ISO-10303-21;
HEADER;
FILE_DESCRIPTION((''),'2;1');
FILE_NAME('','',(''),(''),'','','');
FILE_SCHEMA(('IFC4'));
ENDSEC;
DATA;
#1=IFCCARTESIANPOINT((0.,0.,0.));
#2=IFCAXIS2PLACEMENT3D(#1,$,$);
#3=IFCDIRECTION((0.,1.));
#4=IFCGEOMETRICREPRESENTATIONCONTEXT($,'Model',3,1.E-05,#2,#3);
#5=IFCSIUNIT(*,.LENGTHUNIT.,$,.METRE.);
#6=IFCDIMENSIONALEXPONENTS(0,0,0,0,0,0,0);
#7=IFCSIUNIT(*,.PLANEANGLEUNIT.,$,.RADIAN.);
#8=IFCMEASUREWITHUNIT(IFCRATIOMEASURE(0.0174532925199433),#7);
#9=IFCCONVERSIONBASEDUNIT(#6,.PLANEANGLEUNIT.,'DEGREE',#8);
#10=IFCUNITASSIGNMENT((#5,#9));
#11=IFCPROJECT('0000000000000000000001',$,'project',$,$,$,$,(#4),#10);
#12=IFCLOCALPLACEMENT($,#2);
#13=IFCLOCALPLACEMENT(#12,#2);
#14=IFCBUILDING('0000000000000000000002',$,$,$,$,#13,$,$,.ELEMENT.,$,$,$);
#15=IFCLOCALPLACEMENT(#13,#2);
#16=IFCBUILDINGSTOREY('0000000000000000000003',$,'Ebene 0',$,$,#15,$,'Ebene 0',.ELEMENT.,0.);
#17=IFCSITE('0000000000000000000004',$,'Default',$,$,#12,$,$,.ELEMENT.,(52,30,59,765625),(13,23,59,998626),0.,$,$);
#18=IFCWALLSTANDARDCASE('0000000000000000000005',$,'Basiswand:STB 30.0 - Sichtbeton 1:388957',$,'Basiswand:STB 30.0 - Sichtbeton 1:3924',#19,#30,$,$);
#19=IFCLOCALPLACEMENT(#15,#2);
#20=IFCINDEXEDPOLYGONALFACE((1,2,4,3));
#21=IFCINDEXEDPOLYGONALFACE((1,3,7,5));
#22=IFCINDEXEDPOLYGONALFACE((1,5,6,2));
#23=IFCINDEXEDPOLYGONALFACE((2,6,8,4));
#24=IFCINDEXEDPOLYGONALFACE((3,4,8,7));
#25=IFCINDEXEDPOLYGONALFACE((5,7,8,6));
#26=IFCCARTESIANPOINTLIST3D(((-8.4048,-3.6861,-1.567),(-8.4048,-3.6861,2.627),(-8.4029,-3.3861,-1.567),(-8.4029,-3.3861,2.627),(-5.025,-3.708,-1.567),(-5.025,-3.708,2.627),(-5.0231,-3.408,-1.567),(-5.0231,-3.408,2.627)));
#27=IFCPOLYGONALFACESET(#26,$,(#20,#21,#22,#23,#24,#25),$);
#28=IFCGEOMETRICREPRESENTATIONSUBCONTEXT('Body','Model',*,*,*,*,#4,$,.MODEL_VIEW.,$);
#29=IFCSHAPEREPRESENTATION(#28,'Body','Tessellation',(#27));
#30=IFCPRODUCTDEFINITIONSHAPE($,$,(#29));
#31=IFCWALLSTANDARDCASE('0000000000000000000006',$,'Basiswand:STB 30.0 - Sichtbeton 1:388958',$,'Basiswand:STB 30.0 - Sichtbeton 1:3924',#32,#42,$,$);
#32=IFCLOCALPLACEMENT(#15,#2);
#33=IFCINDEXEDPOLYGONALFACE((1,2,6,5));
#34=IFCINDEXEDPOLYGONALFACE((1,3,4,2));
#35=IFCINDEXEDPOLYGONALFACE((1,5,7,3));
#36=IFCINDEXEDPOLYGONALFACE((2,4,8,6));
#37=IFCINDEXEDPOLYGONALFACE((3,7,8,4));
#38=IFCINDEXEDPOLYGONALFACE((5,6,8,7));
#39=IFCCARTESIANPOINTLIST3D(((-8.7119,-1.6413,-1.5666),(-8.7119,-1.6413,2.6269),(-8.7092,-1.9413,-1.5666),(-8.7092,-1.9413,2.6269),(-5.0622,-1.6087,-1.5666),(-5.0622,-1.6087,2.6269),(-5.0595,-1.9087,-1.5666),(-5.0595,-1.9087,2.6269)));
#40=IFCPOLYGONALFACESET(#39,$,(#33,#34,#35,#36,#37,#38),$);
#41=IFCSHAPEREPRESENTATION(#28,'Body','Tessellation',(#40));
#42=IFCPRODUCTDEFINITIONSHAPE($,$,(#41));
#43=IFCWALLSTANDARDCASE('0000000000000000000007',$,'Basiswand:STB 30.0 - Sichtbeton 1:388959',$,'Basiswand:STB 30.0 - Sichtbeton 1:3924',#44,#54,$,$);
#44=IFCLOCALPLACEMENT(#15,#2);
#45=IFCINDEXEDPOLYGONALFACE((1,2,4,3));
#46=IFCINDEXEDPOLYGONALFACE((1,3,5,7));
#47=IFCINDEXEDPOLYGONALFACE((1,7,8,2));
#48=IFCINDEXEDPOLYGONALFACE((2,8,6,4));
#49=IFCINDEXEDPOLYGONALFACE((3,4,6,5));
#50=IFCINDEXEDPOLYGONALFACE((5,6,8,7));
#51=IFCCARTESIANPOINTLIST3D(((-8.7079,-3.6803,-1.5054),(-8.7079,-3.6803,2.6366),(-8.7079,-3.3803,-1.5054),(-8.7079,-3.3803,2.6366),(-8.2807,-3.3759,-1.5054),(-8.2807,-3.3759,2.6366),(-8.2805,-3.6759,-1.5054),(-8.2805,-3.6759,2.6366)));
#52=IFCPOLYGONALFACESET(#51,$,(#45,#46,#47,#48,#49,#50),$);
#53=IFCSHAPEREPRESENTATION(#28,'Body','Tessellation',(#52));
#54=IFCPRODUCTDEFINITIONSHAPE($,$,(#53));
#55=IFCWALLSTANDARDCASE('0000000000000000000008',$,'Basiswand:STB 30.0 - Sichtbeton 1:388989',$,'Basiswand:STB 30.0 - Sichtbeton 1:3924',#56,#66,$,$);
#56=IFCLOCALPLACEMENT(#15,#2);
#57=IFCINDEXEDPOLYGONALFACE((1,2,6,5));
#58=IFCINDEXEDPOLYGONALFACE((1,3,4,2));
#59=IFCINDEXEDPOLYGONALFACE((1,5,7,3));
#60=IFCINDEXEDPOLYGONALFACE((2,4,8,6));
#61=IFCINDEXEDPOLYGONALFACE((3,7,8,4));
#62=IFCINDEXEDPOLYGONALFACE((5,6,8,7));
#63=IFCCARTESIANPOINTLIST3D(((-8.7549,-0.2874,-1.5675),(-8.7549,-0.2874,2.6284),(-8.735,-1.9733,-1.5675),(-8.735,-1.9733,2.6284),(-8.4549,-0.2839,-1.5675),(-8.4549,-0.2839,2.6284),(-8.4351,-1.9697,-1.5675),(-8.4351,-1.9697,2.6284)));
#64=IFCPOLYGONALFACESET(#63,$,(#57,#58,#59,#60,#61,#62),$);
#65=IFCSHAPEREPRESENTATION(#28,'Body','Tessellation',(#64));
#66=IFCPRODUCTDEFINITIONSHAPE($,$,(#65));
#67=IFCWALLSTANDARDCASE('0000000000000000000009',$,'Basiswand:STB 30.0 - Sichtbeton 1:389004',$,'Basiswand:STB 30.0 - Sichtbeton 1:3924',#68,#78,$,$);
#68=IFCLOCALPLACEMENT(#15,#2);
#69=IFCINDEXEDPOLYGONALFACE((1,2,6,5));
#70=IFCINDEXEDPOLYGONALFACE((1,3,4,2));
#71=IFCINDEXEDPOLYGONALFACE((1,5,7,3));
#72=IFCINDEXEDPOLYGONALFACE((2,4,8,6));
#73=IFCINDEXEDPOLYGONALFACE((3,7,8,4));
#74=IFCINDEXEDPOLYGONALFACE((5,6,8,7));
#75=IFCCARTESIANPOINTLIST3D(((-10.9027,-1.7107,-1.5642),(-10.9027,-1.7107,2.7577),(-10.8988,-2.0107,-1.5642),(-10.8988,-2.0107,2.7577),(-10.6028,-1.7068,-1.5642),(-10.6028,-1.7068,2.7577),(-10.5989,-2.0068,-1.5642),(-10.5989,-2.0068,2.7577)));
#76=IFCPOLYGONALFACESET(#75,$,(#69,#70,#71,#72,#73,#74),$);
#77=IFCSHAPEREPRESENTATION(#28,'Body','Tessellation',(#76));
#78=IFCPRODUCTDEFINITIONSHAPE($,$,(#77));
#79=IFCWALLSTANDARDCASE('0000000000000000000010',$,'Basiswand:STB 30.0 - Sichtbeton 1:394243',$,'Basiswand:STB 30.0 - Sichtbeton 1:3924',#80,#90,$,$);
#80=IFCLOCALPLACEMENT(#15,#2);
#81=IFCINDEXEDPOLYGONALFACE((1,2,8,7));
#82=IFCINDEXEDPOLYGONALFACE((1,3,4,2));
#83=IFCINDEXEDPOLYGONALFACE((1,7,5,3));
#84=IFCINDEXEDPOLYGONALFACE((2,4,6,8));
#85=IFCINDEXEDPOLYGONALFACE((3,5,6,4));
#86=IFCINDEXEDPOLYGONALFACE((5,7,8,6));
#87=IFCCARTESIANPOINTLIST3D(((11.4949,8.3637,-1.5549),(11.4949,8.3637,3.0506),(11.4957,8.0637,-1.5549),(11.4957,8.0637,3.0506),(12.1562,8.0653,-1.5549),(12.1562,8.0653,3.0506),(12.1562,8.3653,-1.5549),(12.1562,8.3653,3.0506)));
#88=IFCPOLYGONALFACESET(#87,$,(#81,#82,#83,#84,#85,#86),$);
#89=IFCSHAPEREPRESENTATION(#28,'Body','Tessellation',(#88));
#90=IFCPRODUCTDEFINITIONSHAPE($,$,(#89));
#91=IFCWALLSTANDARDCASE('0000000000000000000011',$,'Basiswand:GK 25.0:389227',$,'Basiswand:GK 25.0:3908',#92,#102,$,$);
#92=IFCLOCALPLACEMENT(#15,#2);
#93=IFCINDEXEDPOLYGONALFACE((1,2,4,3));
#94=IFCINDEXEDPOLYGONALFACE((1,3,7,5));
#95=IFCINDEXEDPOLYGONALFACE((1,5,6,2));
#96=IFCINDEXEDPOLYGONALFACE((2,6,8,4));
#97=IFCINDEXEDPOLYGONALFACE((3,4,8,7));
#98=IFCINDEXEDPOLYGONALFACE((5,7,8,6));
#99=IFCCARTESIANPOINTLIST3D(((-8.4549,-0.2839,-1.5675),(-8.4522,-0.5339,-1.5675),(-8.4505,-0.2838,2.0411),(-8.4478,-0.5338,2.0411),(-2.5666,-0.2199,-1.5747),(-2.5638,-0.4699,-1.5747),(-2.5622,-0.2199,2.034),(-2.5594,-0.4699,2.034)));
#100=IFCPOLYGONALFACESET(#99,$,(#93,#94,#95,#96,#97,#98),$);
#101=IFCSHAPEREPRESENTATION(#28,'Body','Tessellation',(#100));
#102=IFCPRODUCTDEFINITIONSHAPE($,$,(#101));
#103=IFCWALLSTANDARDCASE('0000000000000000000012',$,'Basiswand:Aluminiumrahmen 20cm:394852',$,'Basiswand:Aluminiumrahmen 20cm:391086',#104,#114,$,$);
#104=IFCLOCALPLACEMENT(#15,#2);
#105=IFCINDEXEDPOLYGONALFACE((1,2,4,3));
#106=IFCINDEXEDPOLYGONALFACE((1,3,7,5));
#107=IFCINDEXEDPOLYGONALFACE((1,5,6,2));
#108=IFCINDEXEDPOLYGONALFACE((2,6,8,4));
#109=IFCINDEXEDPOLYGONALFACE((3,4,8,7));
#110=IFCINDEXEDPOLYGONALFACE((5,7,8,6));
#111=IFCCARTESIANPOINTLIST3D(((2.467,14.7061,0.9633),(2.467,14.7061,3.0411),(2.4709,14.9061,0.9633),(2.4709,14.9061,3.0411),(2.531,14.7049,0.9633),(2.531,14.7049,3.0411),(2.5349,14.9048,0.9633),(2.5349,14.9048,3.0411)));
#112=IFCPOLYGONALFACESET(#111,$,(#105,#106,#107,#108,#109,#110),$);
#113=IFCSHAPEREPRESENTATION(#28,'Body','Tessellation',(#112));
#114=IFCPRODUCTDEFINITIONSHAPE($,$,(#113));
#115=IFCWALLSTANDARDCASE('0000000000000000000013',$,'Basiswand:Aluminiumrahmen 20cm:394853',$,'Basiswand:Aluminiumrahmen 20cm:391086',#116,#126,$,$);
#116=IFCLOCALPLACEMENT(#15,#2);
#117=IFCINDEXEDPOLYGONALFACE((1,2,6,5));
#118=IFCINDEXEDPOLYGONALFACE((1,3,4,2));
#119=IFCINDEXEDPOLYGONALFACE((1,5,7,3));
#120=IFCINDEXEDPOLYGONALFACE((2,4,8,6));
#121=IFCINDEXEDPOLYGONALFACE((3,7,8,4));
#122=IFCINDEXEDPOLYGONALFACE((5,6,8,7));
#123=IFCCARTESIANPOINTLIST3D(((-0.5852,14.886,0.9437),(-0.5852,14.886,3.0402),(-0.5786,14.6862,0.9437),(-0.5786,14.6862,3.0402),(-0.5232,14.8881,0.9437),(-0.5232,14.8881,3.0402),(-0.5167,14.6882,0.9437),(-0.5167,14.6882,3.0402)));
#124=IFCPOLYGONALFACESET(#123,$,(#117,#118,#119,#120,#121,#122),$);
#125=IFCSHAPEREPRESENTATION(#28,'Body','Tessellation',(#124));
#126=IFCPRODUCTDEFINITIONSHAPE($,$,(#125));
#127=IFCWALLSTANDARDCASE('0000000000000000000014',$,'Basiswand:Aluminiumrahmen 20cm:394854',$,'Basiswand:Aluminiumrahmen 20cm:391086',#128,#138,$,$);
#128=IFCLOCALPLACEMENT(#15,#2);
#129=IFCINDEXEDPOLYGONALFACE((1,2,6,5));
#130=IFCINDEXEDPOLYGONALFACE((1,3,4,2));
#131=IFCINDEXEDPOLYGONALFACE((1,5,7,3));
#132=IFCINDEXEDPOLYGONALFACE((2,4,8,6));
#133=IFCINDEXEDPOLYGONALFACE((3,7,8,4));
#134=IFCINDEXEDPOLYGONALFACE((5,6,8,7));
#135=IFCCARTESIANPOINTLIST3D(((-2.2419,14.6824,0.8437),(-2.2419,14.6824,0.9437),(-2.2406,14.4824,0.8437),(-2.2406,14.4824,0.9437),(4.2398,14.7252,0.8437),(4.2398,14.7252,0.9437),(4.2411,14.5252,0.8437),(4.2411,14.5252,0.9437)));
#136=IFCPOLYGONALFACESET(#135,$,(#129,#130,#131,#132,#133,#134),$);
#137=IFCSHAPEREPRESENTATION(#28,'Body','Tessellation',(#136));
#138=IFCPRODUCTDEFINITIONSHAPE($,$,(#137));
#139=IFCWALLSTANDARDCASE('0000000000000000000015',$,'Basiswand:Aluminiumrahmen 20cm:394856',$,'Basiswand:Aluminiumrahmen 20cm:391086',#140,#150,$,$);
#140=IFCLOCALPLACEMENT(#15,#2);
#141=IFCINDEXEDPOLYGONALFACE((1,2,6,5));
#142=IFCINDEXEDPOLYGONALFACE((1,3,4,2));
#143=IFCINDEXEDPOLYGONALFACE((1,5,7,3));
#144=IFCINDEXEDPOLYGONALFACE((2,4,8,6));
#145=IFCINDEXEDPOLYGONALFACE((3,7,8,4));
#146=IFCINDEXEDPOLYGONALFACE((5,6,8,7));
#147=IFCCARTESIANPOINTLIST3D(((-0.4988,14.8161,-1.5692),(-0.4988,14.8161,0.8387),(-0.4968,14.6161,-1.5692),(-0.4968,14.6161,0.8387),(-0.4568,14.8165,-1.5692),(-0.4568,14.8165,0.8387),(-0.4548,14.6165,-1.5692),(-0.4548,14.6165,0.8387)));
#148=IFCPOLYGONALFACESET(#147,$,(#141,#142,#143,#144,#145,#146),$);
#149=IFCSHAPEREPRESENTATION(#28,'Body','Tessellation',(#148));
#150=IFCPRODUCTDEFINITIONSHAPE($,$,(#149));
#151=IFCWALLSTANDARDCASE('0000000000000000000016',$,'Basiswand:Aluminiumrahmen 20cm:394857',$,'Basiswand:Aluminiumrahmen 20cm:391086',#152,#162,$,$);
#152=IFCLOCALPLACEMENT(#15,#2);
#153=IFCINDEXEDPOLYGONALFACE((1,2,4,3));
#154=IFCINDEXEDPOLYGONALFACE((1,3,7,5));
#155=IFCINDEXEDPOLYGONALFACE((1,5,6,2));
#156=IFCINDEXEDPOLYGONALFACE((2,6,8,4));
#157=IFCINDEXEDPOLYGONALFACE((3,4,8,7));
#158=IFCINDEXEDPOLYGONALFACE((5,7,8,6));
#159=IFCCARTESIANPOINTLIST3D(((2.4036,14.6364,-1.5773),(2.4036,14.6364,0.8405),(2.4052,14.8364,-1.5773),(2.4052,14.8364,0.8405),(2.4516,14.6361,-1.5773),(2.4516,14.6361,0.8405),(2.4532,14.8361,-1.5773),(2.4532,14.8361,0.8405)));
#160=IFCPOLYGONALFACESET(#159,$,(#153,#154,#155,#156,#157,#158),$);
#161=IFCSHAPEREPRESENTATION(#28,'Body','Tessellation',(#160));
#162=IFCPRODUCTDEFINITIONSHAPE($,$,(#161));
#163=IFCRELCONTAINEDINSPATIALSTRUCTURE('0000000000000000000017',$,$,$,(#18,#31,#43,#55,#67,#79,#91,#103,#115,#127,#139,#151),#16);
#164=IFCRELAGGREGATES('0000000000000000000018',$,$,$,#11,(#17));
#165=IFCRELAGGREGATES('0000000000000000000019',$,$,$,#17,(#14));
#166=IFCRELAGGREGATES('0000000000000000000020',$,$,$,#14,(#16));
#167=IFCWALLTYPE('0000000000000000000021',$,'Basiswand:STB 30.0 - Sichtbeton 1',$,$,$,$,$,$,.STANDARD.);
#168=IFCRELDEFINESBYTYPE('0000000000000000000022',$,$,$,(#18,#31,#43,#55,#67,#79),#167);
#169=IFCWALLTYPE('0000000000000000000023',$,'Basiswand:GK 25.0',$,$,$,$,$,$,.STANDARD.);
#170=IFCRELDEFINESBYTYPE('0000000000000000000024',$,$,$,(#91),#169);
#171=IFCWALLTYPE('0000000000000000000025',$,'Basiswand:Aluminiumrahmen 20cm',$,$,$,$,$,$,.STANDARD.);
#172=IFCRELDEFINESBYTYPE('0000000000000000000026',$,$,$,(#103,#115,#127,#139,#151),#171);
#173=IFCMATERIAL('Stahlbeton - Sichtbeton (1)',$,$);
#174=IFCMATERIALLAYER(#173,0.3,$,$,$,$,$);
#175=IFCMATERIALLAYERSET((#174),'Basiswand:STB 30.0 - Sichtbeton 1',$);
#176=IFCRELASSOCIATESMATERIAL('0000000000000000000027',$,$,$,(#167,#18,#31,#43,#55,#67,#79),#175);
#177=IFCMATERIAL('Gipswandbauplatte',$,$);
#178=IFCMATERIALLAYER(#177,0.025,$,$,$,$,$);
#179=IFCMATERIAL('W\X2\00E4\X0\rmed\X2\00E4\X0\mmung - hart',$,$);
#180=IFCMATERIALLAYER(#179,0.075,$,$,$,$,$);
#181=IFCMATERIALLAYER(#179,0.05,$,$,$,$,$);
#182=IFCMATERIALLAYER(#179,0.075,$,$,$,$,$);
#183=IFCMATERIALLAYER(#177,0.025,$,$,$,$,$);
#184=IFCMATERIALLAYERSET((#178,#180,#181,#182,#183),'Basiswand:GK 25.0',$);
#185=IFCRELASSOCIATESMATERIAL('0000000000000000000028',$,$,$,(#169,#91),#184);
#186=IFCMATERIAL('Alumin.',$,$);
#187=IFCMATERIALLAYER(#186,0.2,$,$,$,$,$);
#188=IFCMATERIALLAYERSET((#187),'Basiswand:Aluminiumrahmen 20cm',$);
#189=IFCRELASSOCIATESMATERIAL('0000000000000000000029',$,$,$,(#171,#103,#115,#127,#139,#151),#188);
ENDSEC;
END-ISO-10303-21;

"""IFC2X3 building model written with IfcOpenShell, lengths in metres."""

from ifc_helpers import new_model, entity, si_unit, converted_unit, direction, frame, frame_2d, origin, place, context, subcontext, project, spatial, polyline, rectangle, outline, extrude, clip, halfspace, material, layer, layer_set, layer_usage, type_object, element, save


model = new_model("IFC2X3")

# Units and contexts
model_context = context("Model", 3, precision=1e-05, world=origin(), true_north=direction((0.0, 1.0)))
body_context = subcontext(model_context, "Body", "Model", "MODEL_VIEW")
ifc_project = project(units=[si_unit("LENGTHUNIT", "METRE"), converted_unit("PLANEANGLEUNIT", "DEGREE", entity("IfcRatioMeasure", 0.0174532925199433), si_unit("PLANEANGLEUNIT", "RADIAN"), dimensions=[0, 0, 0, 0, 0, 0, 0])], contexts=[model_context])

# Site, building, storey
site_placement = place(None, origin())
site = spatial("IfcSite", under=ifc_project, at=site_placement, Name="Default", CompositionType="ELEMENT", RefLatitude=(52, 30, 59, 765625), RefLongitude=(13, 23, 59, 998626), RefElevation=0.0)
building_placement = place(site_placement, origin())
building = spatial("IfcBuilding", under=site, at=building_placement, CompositionType="ELEMENT")
storey_placement = place(building_placement, origin())
storey = spatial("IfcBuildingStorey", under=building, at=storey_placement, Name="Ebene 0", LongName="Ebene 0", CompositionType="ELEMENT", Elevation=0.0)

# Walls
ifc_material_1 = material(Name="Stahlbeton - Sichtbeton (1)")
ifc_layer_1 = layer(ifc_material_1, 0.3)
ifc_layer_set_1 = layer_set([ifc_layer_1], Name="Basiswand:STB 30.0 - Sichtbeton 1")
ifc_layer_usage_1 = layer_usage(ifc_layer_set_1, "AXIS2", "POSITIVE", -0.15)
wall_type_1 = type_object("IfcWallType", Name="Basiswand:STB 30.0 - Sichtbeton 1", PredefinedType="STANDARD", material=ifc_layer_set_1)
wall_1_placement = place(storey_placement, frame((-5.024, -3.558, -1.567), z_axis=(0.0, 0.0, 1.0), x_axis=(-0.999979, 0.006472, 0.0)))
element("IfcWallStandardCase", 1, at=wall_1_placement, inside=storey, type_object=wall_type_1, material=ifc_layer_usage_1, Name="Basiswand:STB 30.0 - Sichtbeton 1:388957", ObjectType="Basiswand:STB 30.0 - Sichtbeton 1:3924", context=body_context, shape_type="SweptSolid", body=[
    extrude(rectangle(XDim=3.3799, YDim=0.3, at=frame_2d((1.69, 0.0), x_axis=(-1.0, 0.0))), origin(), (0.0, 0.0, 1.0), 4.194),
])
ifc_layer_usage_2 = layer_usage(ifc_layer_set_1, "AXIS2", "POSITIVE", -0.15)
wall_2_placement = place(storey_placement, frame((-5.0608, -1.7587, -1.5666), z_axis=(0.0, 0.0, 1.0), x_axis=(-0.99996, -0.008941, 0.0)))
element("IfcWallStandardCase", 2, at=wall_2_placement, inside=storey, type_object=wall_type_1, material=ifc_layer_usage_2, Name="Basiswand:STB 30.0 - Sichtbeton 1:388958", ObjectType="Basiswand:STB 30.0 - Sichtbeton 1:3924", context=body_context, shape_type="SweptSolid", body=[
    extrude(rectangle(XDim=3.6498, YDim=0.3, at=frame_2d((1.8249, 0.0), x_axis=(-1.0, 0.0))), origin(), (0.0, 0.0, 1.0), 4.1935),
])
ifc_layer_usage_3 = layer_usage(ifc_layer_set_1, "AXIS2", "POSITIVE", -0.15)
wall_3_placement = place(storey_placement, frame((-8.2792, -3.5259, -1.5054), z_axis=(0.0, 0.0, 1.0), x_axis=(-0.999946, -0.010349, 0.0)))
element("IfcWallStandardCase", 3, at=wall_3_placement, inside=storey, type_object=wall_type_1, material=ifc_layer_usage_3, Name="Basiswand:STB 30.0 - Sichtbeton 1:388959", ObjectType="Basiswand:STB 30.0 - Sichtbeton 1:3924", context=body_context, shape_type="SweptSolid", body=[
    extrude(outline(polyline([(-0.1478, -0.2136), (0.1522, -0.2136), (0.1478, 0.2138), (-0.1522, 0.2135), (-0.1478, -0.2136)])), frame((0.2151, 0.0, 0.0), z_axis=(0.0, 0.0, 1.0), x_axis=(0.010349, 0.999946, 0.0)), (0.0, 0.0, 1.0), 4.142),
])
ifc_layer_usage_4 = layer_usage(ifc_layer_set_1, "AXIS2", "POSITIVE", -0.15)
wall_4_placement = place(storey_placement, frame((-8.585, -1.9715, -1.5675), z_axis=(0.0, 0.0, 1.0), x_axis=(-0.011764, 0.999931, 0.0)))
element("IfcWallStandardCase", 4, at=wall_4_placement, inside=storey, type_object=wall_type_1, material=ifc_layer_usage_4, Name="Basiswand:STB 30.0 - Sichtbeton 1:388989", ObjectType="Basiswand:STB 30.0 - Sichtbeton 1:3924", context=body_context, shape_type="SweptSolid", body=[
    extrude(rectangle(XDim=1.686, YDim=0.3, at=frame_2d((0.843, 0.0), x_axis=(-1.0, 0.0))), origin(), (0.0, 0.0, 1.0), 4.196),
])
ifc_layer_usage_5 = layer_usage(ifc_layer_set_1, "AXIS2", "POSITIVE", -0.15)
wall_5_placement = place(storey_placement, frame((-10.7528, -1.7087, -1.5642), z_axis=(0.0, 0.0, 1.0), x_axis=(0.013004, -0.999915, 0.0)))
element("IfcWallStandardCase", 5, at=wall_5_placement, inside=storey, type_object=wall_type_1, material=ifc_layer_usage_5, Name="Basiswand:STB 30.0 - Sichtbeton 1:389004", ObjectType="Basiswand:STB 30.0 - Sichtbeton 1:3924", context=body_context, shape_type="SweptSolid", body=[
    extrude(rectangle(XDim=0.3, YDim=0.3, at=frame_2d((0.15, 0.0), x_axis=(-1.0, 0.0))), origin(), (0.0, 0.0, 1.0), 4.3219),
])
ifc_layer_usage_6 = layer_usage(ifc_layer_set_1, "AXIS2", "POSITIVE", -0.15)
wall_6_placement = place(storey_placement, frame((11.4953, 8.2137, -1.5549), z_axis=(0.0, 0.0, 1.0), x_axis=(0.999997, 0.002516, 0.0)))
element("IfcWallStandardCase", 6, at=wall_6_placement, inside=storey, type_object=wall_type_1, material=ifc_layer_usage_6, Name="Basiswand:STB 30.0 - Sichtbeton 1:394243", ObjectType="Basiswand:STB 30.0 - Sichtbeton 1:3924", context=body_context, shape_type="SweptSolid", body=[
    extrude(outline(polyline([(-0.1492, -0.3305), (0.1508, -0.3305), (0.1492, 0.3309), (-0.1508, 0.3301), (-0.1492, -0.3305)])), frame((0.3305, 0.0, 0.0), z_axis=(0.0, 0.0, 1.0), x_axis=(0.002516, 0.999997, 0.0)), (0.0, 0.0, 1.0), 4.6055),
])
ifc_material_2 = material(Name="Gipswandbauplatte")
ifc_layer_2 = layer(ifc_material_2, 0.025)
ifc_material_3 = material(Name="Wärmedämmung - hart")
ifc_layer_3 = layer(ifc_material_3, 0.075)
ifc_layer_4 = layer(ifc_material_3, 0.05)
ifc_layer_5 = layer(ifc_material_3, 0.075)
ifc_layer_6 = layer(ifc_material_2, 0.025)
ifc_layer_set_2 = layer_set([ifc_layer_2, ifc_layer_3, ifc_layer_4, ifc_layer_5, ifc_layer_6], Name="Basiswand:GK 25.0")
ifc_layer_usage_7 = layer_usage(ifc_layer_set_2, "AXIS2", "POSITIVE", -0.125)
wall_type_2 = type_object("IfcWallType", Name="Basiswand:GK 25.0", PredefinedType="STANDARD", material=ifc_layer_set_2)
wall_7_placement = place(storey_placement, frame((-8.4535, -0.4089, -1.5747), z_axis=(0.0, 0.0, 1.0), x_axis=(0.999941, 0.010858, 0.0)))
element("IfcWallStandardCase", 7, at=wall_7_placement, inside=storey, type_object=wall_type_2, material=ifc_layer_usage_7, Name="Basiswand:GK 25.0:389227", ObjectType="Basiswand:GK 25.0:3908", context=body_context, shape_type="Clipping", body=[
    clip(clip(clip(clip(extrude(rectangle(XDim=5.8931, YDim=0.25, at=frame_2d((2.9465, 0.0), x_axis=(-1.0, 0.0))), origin(), (0.0, 0.0, 1.0), 3.6158), halfspace(frame((5.8887, -0.125, 0.0), z_axis=(-0.001221, 0.0, -0.999999), x_axis=(0.0, 1.0, 0.0)), False)), halfspace(frame((5.8931, -0.125, 3.6087), z_axis=(0.999999, 0.0, -0.001216), x_axis=(0.0, 1.0, 0.0)), False)), halfspace(frame((0.0044, -0.125, 3.6158), z_axis=(0.00121, 0.0, 0.999999), x_axis=(0.0, 1.0, 0.0)), False)), halfspace(frame((0.0, -0.125, 0.0072), z_axis=(-0.999999, 0.0, 0.001216), x_axis=(0.0, 1.0, 0.0)), False)),
])
ifc_material_4 = material(Name="Alumin.")
ifc_layer_7 = layer(ifc_material_4, 0.2)
ifc_layer_set_3 = layer_set([ifc_layer_7], Name="Basiswand:Aluminiumrahmen 20cm")
ifc_layer_usage_8 = layer_usage(ifc_layer_set_3, "AXIS2", "POSITIVE", -0.1)
wall_type_3 = type_object("IfcWallType", Name="Basiswand:Aluminiumrahmen 20cm", PredefinedType="STANDARD", material=ifc_layer_set_3)
wall_8_placement = place(storey_placement, frame((2.4689, 14.8061, 0.9633), z_axis=(0.0, 0.0, 1.0), x_axis=(0.999806, -0.019678, 0.0)))
element("IfcWallStandardCase", 8, at=wall_8_placement, inside=storey, type_object=wall_type_3, material=ifc_layer_usage_8, Name="Basiswand:Aluminiumrahmen 20cm:394852", ObjectType="Basiswand:Aluminiumrahmen 20cm:391086", context=body_context, shape_type="SweptSolid", body=[
    extrude(rectangle(XDim=0.064, YDim=0.2, at=frame_2d((0.032, 0.0), x_axis=(-1.0, 0.0))), origin(), (0.0, 0.0, 1.0), 2.0778),
])
ifc_layer_usage_9 = layer_usage(ifc_layer_set_3, "AXIS2", "POSITIVE", -0.1)
wall_9_placement = place(storey_placement, frame((-0.5819, 14.7861, 0.9437), z_axis=(0.0, 0.0, 1.0), x_axis=(0.999461, 0.032841, 0.0)))
element("IfcWallStandardCase", 9, at=wall_9_placement, inside=storey, type_object=wall_type_3, material=ifc_layer_usage_9, Name="Basiswand:Aluminiumrahmen 20cm:394853", ObjectType="Basiswand:Aluminiumrahmen 20cm:391086", context=body_context, shape_type="SweptSolid", body=[
    extrude(rectangle(XDim=0.062, YDim=0.2, at=frame_2d((0.031, 0.0), x_axis=(-1.0, 0.0))), origin(), (0.0, 0.0, 1.0), 2.0965),
])
ifc_layer_usage_10 = layer_usage(ifc_layer_set_3, "AXIS2", "POSITIVE", -0.1)
wall_10_placement = place(storey_placement, frame((-2.2413, 14.5824, 0.8437), z_axis=(0.0, 0.0, 1.0), x_axis=(0.999978, 0.006605, 0.0)))
element("IfcWallStandardCase", 10, at=wall_10_placement, inside=storey, type_object=wall_type_3, material=ifc_layer_usage_10, Name="Basiswand:Aluminiumrahmen 20cm:394854", ObjectType="Basiswand:Aluminiumrahmen 20cm:391086", context=body_context, shape_type="SweptSolid", body=[
    extrude(rectangle(XDim=6.4819, YDim=0.2, at=frame_2d((3.2409, 0.0), x_axis=(-1.0, 0.0))), origin(), (0.0, 0.0, 1.0), 0.1),
])
ifc_layer_usage_11 = layer_usage(ifc_layer_set_3, "AXIS2", "POSITIVE", -0.1)
wall_11_placement = place(storey_placement, frame((-0.4978, 14.7161, -1.5692), z_axis=(0.0, 0.0, 1.0), x_axis=(0.999953, 0.009708, 0.0)))
element("IfcWallStandardCase", 11, at=wall_11_placement, inside=storey, type_object=wall_type_3, material=ifc_layer_usage_11, Name="Basiswand:Aluminiumrahmen 20cm:394856", ObjectType="Basiswand:Aluminiumrahmen 20cm:391086", context=body_context, shape_type="SweptSolid", body=[
    extrude(rectangle(XDim=0.042, YDim=0.2, at=frame_2d((0.021, 0.0), x_axis=(-1.0, 0.0))), origin(), (0.0, 0.0, 1.0), 2.4079),
])
ifc_layer_usage_12 = layer_usage(ifc_layer_set_3, "AXIS2", "POSITIVE", -0.1)
wall_12_placement = place(storey_placement, frame((2.4044, 14.7364, -1.5773), z_axis=(0.0, 0.0, 1.0), x_axis=(0.999971, -0.007644, 0.0)))
element("IfcWallStandardCase", 12, at=wall_12_placement, inside=storey, type_object=wall_type_3, material=ifc_layer_usage_12, Name="Basiswand:Aluminiumrahmen 20cm:394857", ObjectType="Basiswand:Aluminiumrahmen 20cm:391086", context=body_context, shape_type="SweptSolid", body=[
    extrude(rectangle(XDim=0.048, YDim=0.2, at=frame_2d((0.024, 0.0), x_axis=(-1.0, 0.0))), origin(), (0.0, 0.0, 1.0), 2.4179),
])

save(model, "model.ifc")
